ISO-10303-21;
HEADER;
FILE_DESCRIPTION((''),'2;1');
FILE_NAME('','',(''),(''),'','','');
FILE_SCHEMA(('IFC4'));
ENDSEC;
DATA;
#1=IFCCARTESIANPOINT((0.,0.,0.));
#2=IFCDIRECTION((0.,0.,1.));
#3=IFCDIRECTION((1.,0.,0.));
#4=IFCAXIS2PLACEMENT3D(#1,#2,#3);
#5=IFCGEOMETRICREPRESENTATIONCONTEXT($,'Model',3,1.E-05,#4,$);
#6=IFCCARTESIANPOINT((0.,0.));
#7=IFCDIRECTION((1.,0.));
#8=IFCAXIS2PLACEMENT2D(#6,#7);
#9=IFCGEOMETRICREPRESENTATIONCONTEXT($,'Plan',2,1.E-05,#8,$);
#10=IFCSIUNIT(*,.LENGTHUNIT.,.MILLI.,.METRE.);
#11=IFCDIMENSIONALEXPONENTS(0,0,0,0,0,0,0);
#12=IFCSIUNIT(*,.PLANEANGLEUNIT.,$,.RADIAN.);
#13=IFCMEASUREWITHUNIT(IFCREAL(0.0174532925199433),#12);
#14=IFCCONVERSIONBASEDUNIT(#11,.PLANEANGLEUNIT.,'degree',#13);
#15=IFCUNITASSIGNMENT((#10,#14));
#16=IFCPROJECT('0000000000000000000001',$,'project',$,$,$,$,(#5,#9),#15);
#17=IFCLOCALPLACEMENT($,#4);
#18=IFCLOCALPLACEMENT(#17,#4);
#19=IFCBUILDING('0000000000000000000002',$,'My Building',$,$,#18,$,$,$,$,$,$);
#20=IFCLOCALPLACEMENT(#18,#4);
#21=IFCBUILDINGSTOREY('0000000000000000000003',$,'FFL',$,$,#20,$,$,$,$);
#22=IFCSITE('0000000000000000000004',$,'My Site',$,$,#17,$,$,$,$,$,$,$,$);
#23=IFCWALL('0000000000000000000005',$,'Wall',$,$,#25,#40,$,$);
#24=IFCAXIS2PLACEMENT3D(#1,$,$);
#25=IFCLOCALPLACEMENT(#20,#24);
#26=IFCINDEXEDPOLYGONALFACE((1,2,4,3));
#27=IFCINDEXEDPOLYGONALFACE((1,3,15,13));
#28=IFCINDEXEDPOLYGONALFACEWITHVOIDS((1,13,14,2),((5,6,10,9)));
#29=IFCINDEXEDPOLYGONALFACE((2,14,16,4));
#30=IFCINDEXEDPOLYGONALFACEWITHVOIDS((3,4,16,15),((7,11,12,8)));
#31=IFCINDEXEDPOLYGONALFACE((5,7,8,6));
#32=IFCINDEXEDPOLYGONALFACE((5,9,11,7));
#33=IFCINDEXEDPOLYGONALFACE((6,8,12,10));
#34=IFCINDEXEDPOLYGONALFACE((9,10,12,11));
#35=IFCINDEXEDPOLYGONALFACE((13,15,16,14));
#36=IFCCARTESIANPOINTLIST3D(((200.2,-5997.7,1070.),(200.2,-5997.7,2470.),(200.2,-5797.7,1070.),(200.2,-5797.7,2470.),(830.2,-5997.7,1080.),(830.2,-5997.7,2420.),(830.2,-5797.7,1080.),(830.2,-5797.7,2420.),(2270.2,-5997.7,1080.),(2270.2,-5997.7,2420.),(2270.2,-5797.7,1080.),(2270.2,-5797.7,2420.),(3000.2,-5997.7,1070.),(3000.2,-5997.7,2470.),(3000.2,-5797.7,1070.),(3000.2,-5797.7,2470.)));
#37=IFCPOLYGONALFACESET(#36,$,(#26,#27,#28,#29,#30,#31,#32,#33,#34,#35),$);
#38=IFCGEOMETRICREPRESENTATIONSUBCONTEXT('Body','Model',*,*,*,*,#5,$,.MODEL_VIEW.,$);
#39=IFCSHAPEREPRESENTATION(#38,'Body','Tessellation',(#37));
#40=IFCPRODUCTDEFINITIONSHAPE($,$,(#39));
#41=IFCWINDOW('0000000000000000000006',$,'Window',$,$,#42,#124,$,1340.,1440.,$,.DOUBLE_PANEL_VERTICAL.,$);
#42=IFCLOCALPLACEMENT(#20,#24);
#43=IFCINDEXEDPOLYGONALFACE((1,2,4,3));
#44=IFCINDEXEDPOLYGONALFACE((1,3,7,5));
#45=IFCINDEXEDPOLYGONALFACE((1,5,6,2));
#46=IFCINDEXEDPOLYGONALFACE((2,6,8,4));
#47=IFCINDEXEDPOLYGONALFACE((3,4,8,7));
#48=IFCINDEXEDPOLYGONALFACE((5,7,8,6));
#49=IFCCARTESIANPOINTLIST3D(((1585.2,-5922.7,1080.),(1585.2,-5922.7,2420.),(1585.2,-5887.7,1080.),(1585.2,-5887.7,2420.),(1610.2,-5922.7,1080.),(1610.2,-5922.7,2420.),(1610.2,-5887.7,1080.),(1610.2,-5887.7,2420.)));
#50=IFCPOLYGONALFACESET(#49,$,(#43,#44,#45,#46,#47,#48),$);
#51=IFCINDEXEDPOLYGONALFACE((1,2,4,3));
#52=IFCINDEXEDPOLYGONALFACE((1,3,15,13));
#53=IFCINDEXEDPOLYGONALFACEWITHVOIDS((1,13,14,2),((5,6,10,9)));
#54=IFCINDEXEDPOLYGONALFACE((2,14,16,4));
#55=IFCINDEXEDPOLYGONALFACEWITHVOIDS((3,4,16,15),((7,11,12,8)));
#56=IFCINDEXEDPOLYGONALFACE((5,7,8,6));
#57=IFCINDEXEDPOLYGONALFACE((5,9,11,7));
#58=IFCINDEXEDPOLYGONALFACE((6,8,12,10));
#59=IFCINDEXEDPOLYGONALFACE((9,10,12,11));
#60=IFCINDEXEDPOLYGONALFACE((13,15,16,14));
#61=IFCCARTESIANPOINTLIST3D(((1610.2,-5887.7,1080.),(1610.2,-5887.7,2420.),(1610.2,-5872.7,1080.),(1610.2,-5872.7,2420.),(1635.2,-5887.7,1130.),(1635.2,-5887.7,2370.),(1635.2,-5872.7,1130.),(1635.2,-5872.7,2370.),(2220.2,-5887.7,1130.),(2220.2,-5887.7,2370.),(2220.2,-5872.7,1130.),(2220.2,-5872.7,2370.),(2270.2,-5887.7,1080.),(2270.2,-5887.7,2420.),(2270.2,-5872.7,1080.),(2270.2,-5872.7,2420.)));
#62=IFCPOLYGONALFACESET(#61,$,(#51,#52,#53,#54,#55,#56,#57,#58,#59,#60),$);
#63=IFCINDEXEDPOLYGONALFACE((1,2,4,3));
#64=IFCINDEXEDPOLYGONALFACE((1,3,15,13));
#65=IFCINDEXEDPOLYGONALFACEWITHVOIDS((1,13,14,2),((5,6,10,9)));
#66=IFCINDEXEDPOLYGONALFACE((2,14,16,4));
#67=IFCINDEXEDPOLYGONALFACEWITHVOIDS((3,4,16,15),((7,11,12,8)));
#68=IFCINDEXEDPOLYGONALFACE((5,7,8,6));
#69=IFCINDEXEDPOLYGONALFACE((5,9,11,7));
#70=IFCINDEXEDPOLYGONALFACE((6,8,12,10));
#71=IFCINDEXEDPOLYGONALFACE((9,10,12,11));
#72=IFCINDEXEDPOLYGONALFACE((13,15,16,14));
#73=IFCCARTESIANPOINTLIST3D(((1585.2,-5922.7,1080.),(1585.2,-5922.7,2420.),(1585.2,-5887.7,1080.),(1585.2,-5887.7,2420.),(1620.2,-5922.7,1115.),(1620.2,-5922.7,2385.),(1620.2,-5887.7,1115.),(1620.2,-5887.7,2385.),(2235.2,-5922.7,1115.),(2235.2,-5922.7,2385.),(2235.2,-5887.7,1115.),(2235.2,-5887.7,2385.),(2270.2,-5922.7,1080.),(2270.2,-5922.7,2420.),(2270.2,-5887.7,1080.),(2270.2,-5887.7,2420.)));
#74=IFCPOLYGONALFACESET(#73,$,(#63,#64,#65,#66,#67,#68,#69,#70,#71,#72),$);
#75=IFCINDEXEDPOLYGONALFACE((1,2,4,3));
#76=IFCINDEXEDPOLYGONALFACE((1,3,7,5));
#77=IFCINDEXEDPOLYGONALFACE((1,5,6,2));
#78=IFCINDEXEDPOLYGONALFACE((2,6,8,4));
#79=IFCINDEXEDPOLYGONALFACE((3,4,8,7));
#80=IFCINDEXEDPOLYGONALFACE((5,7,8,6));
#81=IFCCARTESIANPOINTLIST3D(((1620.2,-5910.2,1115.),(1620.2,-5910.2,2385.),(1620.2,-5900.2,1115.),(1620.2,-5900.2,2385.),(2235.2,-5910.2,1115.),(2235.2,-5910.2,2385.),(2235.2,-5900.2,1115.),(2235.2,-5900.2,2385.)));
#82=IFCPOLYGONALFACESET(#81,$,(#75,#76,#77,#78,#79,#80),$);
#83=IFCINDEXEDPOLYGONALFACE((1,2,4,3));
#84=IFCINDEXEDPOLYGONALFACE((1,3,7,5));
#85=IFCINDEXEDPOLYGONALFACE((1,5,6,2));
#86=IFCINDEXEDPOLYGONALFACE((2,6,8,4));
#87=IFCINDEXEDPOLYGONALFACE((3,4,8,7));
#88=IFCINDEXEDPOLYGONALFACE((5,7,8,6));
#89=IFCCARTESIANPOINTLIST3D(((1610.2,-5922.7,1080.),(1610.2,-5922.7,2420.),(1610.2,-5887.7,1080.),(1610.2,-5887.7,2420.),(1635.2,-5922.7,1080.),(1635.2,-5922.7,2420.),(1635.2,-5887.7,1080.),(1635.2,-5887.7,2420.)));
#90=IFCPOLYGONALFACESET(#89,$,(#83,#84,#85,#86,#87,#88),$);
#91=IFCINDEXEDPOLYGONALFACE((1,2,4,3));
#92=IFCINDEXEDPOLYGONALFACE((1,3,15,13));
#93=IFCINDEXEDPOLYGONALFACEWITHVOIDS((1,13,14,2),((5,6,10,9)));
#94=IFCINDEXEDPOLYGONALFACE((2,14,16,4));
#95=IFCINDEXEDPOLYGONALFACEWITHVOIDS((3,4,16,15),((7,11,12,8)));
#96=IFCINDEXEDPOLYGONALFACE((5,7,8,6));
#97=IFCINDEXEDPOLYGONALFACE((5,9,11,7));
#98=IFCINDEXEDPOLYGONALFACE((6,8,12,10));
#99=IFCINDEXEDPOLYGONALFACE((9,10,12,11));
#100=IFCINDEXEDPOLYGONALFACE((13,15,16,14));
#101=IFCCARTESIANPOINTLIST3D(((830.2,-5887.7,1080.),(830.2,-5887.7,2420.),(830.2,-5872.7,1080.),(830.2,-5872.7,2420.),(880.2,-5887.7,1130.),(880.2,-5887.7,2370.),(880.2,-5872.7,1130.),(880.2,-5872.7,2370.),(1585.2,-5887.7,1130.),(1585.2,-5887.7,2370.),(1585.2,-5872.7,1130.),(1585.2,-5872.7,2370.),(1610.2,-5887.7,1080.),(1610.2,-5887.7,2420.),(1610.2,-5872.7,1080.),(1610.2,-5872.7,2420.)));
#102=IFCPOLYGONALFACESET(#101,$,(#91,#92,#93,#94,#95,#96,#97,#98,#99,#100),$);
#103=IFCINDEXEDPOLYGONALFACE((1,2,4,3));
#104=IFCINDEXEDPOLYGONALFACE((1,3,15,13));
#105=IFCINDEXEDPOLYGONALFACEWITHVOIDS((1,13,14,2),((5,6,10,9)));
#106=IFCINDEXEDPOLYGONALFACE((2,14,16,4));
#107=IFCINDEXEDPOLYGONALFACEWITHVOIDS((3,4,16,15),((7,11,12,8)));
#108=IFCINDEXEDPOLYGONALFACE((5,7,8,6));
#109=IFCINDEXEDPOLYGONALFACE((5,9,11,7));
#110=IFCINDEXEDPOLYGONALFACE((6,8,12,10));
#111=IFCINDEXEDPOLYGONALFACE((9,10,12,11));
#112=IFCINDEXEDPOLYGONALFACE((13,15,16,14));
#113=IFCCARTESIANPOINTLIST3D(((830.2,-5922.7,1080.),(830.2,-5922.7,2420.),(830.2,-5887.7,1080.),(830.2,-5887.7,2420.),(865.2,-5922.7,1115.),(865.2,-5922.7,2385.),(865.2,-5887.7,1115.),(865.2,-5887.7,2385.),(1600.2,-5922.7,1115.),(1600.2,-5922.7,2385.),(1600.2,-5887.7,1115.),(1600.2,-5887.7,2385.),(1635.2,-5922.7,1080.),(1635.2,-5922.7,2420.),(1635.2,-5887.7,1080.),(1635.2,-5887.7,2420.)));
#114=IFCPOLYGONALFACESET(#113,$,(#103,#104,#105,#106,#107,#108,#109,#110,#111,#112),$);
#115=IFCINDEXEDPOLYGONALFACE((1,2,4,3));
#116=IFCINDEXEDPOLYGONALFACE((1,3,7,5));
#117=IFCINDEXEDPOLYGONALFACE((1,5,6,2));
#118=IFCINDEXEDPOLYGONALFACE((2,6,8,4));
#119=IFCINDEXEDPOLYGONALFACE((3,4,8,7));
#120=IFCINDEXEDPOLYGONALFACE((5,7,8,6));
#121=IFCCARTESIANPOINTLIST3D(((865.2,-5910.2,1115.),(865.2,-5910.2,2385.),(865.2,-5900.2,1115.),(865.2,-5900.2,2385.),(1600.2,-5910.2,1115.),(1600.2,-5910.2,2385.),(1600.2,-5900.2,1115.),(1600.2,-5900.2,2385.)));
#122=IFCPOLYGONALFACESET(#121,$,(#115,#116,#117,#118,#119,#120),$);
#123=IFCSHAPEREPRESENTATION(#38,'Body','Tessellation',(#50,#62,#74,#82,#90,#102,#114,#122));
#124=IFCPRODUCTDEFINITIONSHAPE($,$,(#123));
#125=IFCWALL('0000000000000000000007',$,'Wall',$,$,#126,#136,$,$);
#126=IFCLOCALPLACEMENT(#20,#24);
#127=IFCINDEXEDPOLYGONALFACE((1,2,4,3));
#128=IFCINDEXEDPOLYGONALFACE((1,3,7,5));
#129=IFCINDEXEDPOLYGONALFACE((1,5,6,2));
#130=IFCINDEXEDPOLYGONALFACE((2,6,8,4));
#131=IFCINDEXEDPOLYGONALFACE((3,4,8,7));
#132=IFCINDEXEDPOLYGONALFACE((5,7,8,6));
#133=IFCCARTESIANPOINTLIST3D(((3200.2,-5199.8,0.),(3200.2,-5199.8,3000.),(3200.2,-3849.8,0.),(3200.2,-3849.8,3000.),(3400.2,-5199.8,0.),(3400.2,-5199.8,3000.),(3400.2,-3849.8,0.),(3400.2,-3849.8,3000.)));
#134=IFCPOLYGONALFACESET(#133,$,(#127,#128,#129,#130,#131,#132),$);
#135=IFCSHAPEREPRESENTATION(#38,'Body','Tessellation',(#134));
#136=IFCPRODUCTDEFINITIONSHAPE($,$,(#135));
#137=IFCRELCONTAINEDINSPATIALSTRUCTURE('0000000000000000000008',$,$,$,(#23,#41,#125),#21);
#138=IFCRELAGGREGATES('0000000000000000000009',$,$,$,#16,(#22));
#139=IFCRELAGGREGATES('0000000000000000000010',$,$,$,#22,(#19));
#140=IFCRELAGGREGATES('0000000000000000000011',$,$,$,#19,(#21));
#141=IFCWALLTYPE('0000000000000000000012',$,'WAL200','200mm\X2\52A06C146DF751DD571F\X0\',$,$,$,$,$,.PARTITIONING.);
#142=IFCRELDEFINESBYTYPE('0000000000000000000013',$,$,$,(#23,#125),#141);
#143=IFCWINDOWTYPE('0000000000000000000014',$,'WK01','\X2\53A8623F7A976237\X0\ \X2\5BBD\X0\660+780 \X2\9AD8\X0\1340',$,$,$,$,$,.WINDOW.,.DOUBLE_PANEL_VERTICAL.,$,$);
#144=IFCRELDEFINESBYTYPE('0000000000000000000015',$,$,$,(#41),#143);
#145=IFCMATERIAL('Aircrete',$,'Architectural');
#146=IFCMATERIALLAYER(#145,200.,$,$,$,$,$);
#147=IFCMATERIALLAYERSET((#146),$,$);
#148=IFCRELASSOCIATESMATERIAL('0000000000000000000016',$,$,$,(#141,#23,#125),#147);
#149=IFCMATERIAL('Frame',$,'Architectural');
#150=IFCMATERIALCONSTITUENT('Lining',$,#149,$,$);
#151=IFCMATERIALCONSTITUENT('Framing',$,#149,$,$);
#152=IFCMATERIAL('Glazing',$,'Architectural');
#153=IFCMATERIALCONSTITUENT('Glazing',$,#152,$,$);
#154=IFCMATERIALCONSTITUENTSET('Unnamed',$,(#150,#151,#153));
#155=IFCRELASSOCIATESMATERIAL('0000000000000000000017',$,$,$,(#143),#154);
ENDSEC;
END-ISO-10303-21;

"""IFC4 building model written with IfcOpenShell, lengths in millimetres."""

from ifc_helpers import new_model, entity, si_unit, converted_unit, frame, origin_with_axes, origin_2d_with_axis, place, context, subcontext, project, spatial, line, indexed_curve, outline, extrude, shape, source, transform, mapped, material, layer, layer_set, layer_usage, constituent, constituent_set, type_object, type_shapes, element, fill, save


model = new_model("IFC4")

# Units and contexts
model_context = context("Model", 3, precision=1e-05, world=origin_with_axes())
plan_context = context("Plan", 2, precision=1e-05, world=origin_2d_with_axis())
body_context_1 = subcontext(model_context, "Body", "Model", "MODEL_VIEW")
body_context_2 = subcontext(plan_context, "Body", "Plan", "PLAN_VIEW")
ifc_project = project(units=[si_unit("LENGTHUNIT", "METRE", prefix="MILLI"), converted_unit("PLANEANGLEUNIT", "degree", entity("IfcReal", 0.0174532925199433), si_unit("PLANEANGLEUNIT", "RADIAN"), dimensions=[0, 0, 0, 0, 0, 0, 0])], contexts=[model_context, plan_context])

# Site, building, storey
site_placement = place(None, origin_with_axes())
site = spatial("IfcSite", under=ifc_project, at=site_placement, Name="My Site")
building_placement = place(site_placement, origin_with_axes())
building = spatial("IfcBuilding", under=site, at=building_placement, Name="My Building")
storey_placement = place(building_placement, origin_with_axes())
storey = spatial("IfcBuildingStorey", under=building, at=storey_placement, Name="FFL")

# Shared definitions
ifc_material_1 = material(Name="Aircrete", Category="Architectural")

# Wall, opening, window
ifc_layer_1 = layer(ifc_material_1, 200.0)
ifc_layer_set_1 = layer_set([ifc_layer_1])
ifc_layer_usage_1 = layer_usage(ifc_layer_set_1, "AXIS2", "NEGATIVE", 0.0)
wall_type_1 = type_object("IfcWallType", Name="WAL200", Description="200mm加气混凝土", PredefinedType="PARTITIONING", material=ifc_layer_set_1)
wall_1_placement = place(storey_placement, frame((200.2, -5797.7, 1070.0), z_axis=(0.0, 0.0, 1.0), x_axis=(1.0, 0.0, 0.0)))
wall_1 = element("IfcWall", 1, at=wall_1_placement, inside=storey, type_object=wall_type_1, material=ifc_layer_usage_1, Name="Wall", context=body_context_1, shape_type="SweptSolid", body=[
    extrude(outline(indexed_curve([(0.0, -200.0), (0.0, 0.0), (2800.0, 0.0), (2800.0, -200.0)], segments=[line(1, 2, 3, 4, 1)])), origin_with_axes(), (0.0, 0.0, 1.0), 1400.0),
])
shared_shape_1 = source(origin_with_axes(), body_context_1, "Body", "SweptSolid", [
    extrude(outline(indexed_curve([(0.0, 0.0), (1440.0, 0.0), (1440.0, 1340.0), (0.0, 1340.0)], segments=[line(1, 2, 3, 4, 1)])), frame((0.0, -600.0, 0.0), z_axis=(0.0, -1.0, 0.0), x_axis=(1.0, 0.0, 0.0)), (0.0, 0.0, -1.0), 1200.0),
])
opening_1_placement = place(wall_1_placement, frame((2070.0, -25.0, 10.0), z_axis=(0.0, 0.0, 1.0), x_axis=(-1.0, 0.0, 0.0)))
opening_1 = element("IfcOpeningElement", 2, at=opening_1_placement, cuts=wall_1, PredefinedType="OPENING", context=body_context_1, shape_type="MappedRepresentation", body=[
    mapped(shared_shape_1, transform((0.0, 0.0, 0.0), x_axis=(1.0, 0.0, 0.0), y_axis=(0.0, 1.0, 0.0), z_axis=(0.0, 0.0, 1.0), scale=1.0)),
])
ifc_material_2 = material(Name="Frame", Category="Architectural")
ifc_constituent_1 = constituent(ifc_material_2, Name="Lining")
ifc_constituent_2 = constituent(ifc_material_2, Name="Framing")
ifc_material_3 = material(Name="Glazing", Category="Architectural")
ifc_constituent_3 = constituent(ifc_material_3, Name="Glazing")
ifc_constituent_set_1 = constituent_set(constituents=[ifc_constituent_1, ifc_constituent_2, ifc_constituent_3], Name="Unnamed")
window_type_1 = type_object("IfcWindowType", Name="WK01", Description="厨房窗户 宽660+780 高1340", PartitioningType="DOUBLE_PANEL_VERTICAL", PredefinedType="WINDOW", material=ifc_constituent_set_1)
shared_shape_2 = source(origin_with_axes(), body_context_1, "Body", "SweptSolid", [
    extrude(outline(indexed_curve([(660.0, 1340.0), (660.0, 0.0), (685.0, 0.0), (685.0, 1340.0)], segments=[line(1, 2, 3, 4, 1)])), frame((0.0, 65.0, 0.0), z_axis=(0.0, -1.0, 0.0), x_axis=(1.0, 0.0, 0.0)), (0.0, 0.0, -1.0), 35.0),
    extrude(outline(indexed_curve([(0.0, 0.0), (660.0, 0.0), (660.0, 1340.0), (0.0, 1340.0)], segments=[line(1, 2, 3, 4, 1)]), holes=[indexed_curve([(50.0, 50.0), (635.0, 50.0), (635.0, 1290.0), (50.0, 1290.0)], segments=[line(1, 2, 3, 4, 1)])]), frame((0.0, 50.0, 0.0), z_axis=(0.0, -1.0, 0.0), x_axis=(1.0, 0.0, 0.0)), (0.0, 0.0, -1.0), 15.0),
    extrude(outline(indexed_curve([(0.0, 0.0), (685.0, 0.0), (685.0, 1340.0), (0.0, 1340.0)], segments=[line(1, 2, 3, 4, 1)]), holes=[indexed_curve([(35.0, 35.0), (650.0, 35.0), (650.0, 1305.0), (35.0, 1305.0)], segments=[line(1, 2, 3, 4, 1)])]), frame((0.0, 65.0, 0.0), z_axis=(0.0, -1.0, 0.0), x_axis=(1.0, 0.0, 0.0)), (0.0, 0.0, -1.0), 35.0),
    extrude(outline(indexed_curve([(35.0, 35.0), (650.0, 35.0), (650.0, 1305.0), (35.0, 1305.0)], segments=[line(1, 2, 3, 4, 1)])), frame((0.0, 77.5, 0.0), z_axis=(0.0, -1.0, 0.0), x_axis=(1.0, 0.0, 0.0)), (0.0, 0.0, -1.0), 10.0),
    extrude(outline(indexed_curve([(0.0, 0.0), (0.0, 1340.0), (-25.0, 1340.0), (-25.0, 0.0)], segments=[line(1, 2, 3, 4, 1)])), frame((660.0, 65.0, 0.0), z_axis=(0.0, -1.0, 0.0), x_axis=(1.0, 0.0, 0.0)), (0.0, 0.0, -1.0), 35.0),
    extrude(outline(indexed_curve([(0.0, 0.0), (780.0, 0.0), (780.0, 1340.0), (0.0, 1340.0)], segments=[line(1, 2, 3, 4, 1)]), holes=[indexed_curve([(25.0, 50.0), (730.0, 50.0), (730.0, 1290.0), (25.0, 1290.0)], segments=[line(1, 2, 3, 4, 1)])]), frame((660.0, 50.0, 0.0), z_axis=(0.0, -1.0, 0.0), x_axis=(1.0, 0.0, 0.0)), (0.0, 0.0, -1.0), 15.0),
    extrude(outline(indexed_curve([(0.0, 0.0), (805.0, 0.0), (805.0, 1340.0), (0.0, 1340.0)], segments=[line(1, 2, 3, 4, 1)]), holes=[indexed_curve([(35.0, 35.0), (770.0, 35.0), (770.0, 1305.0), (35.0, 1305.0)], segments=[line(1, 2, 3, 4, 1)])]), frame((635.0, 65.0, 0.0), z_axis=(0.0, -1.0, 0.0), x_axis=(1.0, 0.0, 0.0)), (0.0, 0.0, -1.0), 35.0),
    extrude(outline(indexed_curve([(35.0, 35.0), (770.0, 35.0), (770.0, 1305.0), (35.0, 1305.0)], segments=[line(1, 2, 3, 4, 1)])), frame((635.0, 77.5, 0.0), z_axis=(0.0, -1.0, 0.0), x_axis=(1.0, 0.0, 0.0)), (0.0, 0.0, -1.0), 10.0),
])
shared_shape_3 = source(origin_with_axes(), body_context_2, "Body", "Curve2D", [
    entity("IfcIndexedPolyCurve", entity("IfcCartesianPointList2D", [[50.0, 50.0], [635.0, 50.0]])),
    entity("IfcIndexedPolyCurve", entity("IfcCartesianPointList2D", [[0.0, 100.0], [0.0, 100.0], [0.0, 65.0], [50.0, 65.0], [50.0, 50.0], [0.0, 50.0]]), [entity("IfcLineIndex", [1, 2, 3, 4, 5, 6, 1])]),
    entity("IfcIndexedPolyCurve", entity("IfcCartesianPointList2D", [[660.0, 100.0], [685.0, 100.0], [685.0, 65.0], [635.0, 65.0], [635.0, 50.0], [660.0, 50.0]])),
    entity("IfcIndexedPolyCurve", entity("IfcCartesianPointList2D", [[0.0, 65.0], [35.0, 65.0], [35.0, 100.0], [0.0, 100.0]]), [entity("IfcLineIndex", [1, 2, 3, 4, 1])]),
    entity("IfcIndexedPolyCurve", entity("IfcCartesianPointList2D", [[685.0, 65.0], [650.0, 65.0], [650.0, 100.0], [685.0, 100.0]]), [entity("IfcLineIndex", [1, 2, 3, 4, 1])]),
    entity("IfcIndexedPolyCurve", entity("IfcCartesianPointList2D", [[35.0, 65.0], [650.0, 65.0]])),
    entity("IfcIndexedPolyCurve", entity("IfcCartesianPointList2D", [[35.0, 100.0], [650.0, 100.0]])),
    entity("IfcIndexedPolyCurve", entity("IfcCartesianPointList2D", [[35.0, 82.5], [650.0, 82.5]])),
    entity("IfcIndexedPolyCurve", entity("IfcCartesianPointList2D", [[685.0, 50.0], [1390.0, 50.0]])),
    entity("IfcIndexedPolyCurve", entity("IfcCartesianPointList2D", [[660.0, 100.0], [635.0, 100.0], [635.0, 65.0], [685.0, 65.0], [685.0, 50.0], [660.0, 50.0]])),
    entity("IfcIndexedPolyCurve", entity("IfcCartesianPointList2D", [[1440.0, 100.0], [1440.0, 100.0], [1440.0, 65.0], [1390.0, 65.0], [1390.0, 50.0], [1440.0, 50.0]]), [entity("IfcLineIndex", [1, 2, 3, 4, 5, 6, 1])]),
    entity("IfcIndexedPolyCurve", entity("IfcCartesianPointList2D", [[635.0, 65.0], [670.0, 65.0], [670.0, 100.0], [635.0, 100.0]]), [entity("IfcLineIndex", [1, 2, 3, 4, 1])]),
    entity("IfcIndexedPolyCurve", entity("IfcCartesianPointList2D", [[1440.0, 65.0], [1405.0, 65.0], [1405.0, 100.0], [1440.0, 100.0]]), [entity("IfcLineIndex", [1, 2, 3, 4, 1])]),
    entity("IfcIndexedPolyCurve", entity("IfcCartesianPointList2D", [[670.0, 65.0], [1405.0, 65.0]])),
    entity("IfcIndexedPolyCurve", entity("IfcCartesianPointList2D", [[670.0, 100.0], [1405.0, 100.0]])),
    entity("IfcIndexedPolyCurve", entity("IfcCartesianPointList2D", [[670.0, 82.5], [1405.0, 82.5]])),
])
type_shapes(window_type_1, [shared_shape_2, shared_shape_3])
window_1_placement = place(opening_1_placement, frame((0.0, 0.0, 0.0), z_axis=(0.0, 0.0, 1.0), x_axis=(1.0, 0.0, 0.0)))
window_1 = element("IfcWindow", 3, at=window_1_placement, inside=storey, type_object=window_type_1, Name="Window", OverallHeight=1340.0, OverallWidth=1440.0, PartitioningType="DOUBLE_PANEL_VERTICAL", shapes=[
    shape(body_context_1, "Body", "MappedRepresentation", [mapped(shared_shape_2, transform((0.0, 0.0, 0.0), x_axis=(1.0, 0.0, 0.0), y_axis=(0.0, 1.0, 0.0), z_axis=(0.0, 0.0, 1.0), scale=1.0))]),
    shape(body_context_2, "Body", "MappedRepresentation", [mapped(shared_shape_3, transform((0.0, 0.0, 0.0), x_axis=(1.0, 0.0, 0.0), y_axis=(0.0, 1.0, 0.0), z_axis=(0.0, 0.0, 1.0), scale=1.0))]),
])
fill(opening_1, window_1)

# Wall
ifc_layer_usage_2 = layer_usage(ifc_layer_set_1, "AXIS2", "NEGATIVE", 0.0)
wall_2_placement = place(storey_placement, frame((3200.2, -5199.8, 0.0), z_axis=(0.0, 0.0, 1.0), x_axis=(-0.000007, 1.0, 0.0)))
element("IfcWall", 4, at=wall_2_placement, inside=storey, type_object=wall_type_1, material=ifc_layer_usage_2, Name="Wall", context=body_context_1, shape_type="SweptSolid", body=[
    extrude(outline(indexed_curve([(0.0, -200.0), (0.0, 0.0), (1350.0, 0.0), (1350.0, -200.0)], segments=[line(1, 2, 3, 4, 1)])), origin_with_axes(), (0.0, 0.0, 1.0), 3000.0),
])

save(model, "model.ifc")
